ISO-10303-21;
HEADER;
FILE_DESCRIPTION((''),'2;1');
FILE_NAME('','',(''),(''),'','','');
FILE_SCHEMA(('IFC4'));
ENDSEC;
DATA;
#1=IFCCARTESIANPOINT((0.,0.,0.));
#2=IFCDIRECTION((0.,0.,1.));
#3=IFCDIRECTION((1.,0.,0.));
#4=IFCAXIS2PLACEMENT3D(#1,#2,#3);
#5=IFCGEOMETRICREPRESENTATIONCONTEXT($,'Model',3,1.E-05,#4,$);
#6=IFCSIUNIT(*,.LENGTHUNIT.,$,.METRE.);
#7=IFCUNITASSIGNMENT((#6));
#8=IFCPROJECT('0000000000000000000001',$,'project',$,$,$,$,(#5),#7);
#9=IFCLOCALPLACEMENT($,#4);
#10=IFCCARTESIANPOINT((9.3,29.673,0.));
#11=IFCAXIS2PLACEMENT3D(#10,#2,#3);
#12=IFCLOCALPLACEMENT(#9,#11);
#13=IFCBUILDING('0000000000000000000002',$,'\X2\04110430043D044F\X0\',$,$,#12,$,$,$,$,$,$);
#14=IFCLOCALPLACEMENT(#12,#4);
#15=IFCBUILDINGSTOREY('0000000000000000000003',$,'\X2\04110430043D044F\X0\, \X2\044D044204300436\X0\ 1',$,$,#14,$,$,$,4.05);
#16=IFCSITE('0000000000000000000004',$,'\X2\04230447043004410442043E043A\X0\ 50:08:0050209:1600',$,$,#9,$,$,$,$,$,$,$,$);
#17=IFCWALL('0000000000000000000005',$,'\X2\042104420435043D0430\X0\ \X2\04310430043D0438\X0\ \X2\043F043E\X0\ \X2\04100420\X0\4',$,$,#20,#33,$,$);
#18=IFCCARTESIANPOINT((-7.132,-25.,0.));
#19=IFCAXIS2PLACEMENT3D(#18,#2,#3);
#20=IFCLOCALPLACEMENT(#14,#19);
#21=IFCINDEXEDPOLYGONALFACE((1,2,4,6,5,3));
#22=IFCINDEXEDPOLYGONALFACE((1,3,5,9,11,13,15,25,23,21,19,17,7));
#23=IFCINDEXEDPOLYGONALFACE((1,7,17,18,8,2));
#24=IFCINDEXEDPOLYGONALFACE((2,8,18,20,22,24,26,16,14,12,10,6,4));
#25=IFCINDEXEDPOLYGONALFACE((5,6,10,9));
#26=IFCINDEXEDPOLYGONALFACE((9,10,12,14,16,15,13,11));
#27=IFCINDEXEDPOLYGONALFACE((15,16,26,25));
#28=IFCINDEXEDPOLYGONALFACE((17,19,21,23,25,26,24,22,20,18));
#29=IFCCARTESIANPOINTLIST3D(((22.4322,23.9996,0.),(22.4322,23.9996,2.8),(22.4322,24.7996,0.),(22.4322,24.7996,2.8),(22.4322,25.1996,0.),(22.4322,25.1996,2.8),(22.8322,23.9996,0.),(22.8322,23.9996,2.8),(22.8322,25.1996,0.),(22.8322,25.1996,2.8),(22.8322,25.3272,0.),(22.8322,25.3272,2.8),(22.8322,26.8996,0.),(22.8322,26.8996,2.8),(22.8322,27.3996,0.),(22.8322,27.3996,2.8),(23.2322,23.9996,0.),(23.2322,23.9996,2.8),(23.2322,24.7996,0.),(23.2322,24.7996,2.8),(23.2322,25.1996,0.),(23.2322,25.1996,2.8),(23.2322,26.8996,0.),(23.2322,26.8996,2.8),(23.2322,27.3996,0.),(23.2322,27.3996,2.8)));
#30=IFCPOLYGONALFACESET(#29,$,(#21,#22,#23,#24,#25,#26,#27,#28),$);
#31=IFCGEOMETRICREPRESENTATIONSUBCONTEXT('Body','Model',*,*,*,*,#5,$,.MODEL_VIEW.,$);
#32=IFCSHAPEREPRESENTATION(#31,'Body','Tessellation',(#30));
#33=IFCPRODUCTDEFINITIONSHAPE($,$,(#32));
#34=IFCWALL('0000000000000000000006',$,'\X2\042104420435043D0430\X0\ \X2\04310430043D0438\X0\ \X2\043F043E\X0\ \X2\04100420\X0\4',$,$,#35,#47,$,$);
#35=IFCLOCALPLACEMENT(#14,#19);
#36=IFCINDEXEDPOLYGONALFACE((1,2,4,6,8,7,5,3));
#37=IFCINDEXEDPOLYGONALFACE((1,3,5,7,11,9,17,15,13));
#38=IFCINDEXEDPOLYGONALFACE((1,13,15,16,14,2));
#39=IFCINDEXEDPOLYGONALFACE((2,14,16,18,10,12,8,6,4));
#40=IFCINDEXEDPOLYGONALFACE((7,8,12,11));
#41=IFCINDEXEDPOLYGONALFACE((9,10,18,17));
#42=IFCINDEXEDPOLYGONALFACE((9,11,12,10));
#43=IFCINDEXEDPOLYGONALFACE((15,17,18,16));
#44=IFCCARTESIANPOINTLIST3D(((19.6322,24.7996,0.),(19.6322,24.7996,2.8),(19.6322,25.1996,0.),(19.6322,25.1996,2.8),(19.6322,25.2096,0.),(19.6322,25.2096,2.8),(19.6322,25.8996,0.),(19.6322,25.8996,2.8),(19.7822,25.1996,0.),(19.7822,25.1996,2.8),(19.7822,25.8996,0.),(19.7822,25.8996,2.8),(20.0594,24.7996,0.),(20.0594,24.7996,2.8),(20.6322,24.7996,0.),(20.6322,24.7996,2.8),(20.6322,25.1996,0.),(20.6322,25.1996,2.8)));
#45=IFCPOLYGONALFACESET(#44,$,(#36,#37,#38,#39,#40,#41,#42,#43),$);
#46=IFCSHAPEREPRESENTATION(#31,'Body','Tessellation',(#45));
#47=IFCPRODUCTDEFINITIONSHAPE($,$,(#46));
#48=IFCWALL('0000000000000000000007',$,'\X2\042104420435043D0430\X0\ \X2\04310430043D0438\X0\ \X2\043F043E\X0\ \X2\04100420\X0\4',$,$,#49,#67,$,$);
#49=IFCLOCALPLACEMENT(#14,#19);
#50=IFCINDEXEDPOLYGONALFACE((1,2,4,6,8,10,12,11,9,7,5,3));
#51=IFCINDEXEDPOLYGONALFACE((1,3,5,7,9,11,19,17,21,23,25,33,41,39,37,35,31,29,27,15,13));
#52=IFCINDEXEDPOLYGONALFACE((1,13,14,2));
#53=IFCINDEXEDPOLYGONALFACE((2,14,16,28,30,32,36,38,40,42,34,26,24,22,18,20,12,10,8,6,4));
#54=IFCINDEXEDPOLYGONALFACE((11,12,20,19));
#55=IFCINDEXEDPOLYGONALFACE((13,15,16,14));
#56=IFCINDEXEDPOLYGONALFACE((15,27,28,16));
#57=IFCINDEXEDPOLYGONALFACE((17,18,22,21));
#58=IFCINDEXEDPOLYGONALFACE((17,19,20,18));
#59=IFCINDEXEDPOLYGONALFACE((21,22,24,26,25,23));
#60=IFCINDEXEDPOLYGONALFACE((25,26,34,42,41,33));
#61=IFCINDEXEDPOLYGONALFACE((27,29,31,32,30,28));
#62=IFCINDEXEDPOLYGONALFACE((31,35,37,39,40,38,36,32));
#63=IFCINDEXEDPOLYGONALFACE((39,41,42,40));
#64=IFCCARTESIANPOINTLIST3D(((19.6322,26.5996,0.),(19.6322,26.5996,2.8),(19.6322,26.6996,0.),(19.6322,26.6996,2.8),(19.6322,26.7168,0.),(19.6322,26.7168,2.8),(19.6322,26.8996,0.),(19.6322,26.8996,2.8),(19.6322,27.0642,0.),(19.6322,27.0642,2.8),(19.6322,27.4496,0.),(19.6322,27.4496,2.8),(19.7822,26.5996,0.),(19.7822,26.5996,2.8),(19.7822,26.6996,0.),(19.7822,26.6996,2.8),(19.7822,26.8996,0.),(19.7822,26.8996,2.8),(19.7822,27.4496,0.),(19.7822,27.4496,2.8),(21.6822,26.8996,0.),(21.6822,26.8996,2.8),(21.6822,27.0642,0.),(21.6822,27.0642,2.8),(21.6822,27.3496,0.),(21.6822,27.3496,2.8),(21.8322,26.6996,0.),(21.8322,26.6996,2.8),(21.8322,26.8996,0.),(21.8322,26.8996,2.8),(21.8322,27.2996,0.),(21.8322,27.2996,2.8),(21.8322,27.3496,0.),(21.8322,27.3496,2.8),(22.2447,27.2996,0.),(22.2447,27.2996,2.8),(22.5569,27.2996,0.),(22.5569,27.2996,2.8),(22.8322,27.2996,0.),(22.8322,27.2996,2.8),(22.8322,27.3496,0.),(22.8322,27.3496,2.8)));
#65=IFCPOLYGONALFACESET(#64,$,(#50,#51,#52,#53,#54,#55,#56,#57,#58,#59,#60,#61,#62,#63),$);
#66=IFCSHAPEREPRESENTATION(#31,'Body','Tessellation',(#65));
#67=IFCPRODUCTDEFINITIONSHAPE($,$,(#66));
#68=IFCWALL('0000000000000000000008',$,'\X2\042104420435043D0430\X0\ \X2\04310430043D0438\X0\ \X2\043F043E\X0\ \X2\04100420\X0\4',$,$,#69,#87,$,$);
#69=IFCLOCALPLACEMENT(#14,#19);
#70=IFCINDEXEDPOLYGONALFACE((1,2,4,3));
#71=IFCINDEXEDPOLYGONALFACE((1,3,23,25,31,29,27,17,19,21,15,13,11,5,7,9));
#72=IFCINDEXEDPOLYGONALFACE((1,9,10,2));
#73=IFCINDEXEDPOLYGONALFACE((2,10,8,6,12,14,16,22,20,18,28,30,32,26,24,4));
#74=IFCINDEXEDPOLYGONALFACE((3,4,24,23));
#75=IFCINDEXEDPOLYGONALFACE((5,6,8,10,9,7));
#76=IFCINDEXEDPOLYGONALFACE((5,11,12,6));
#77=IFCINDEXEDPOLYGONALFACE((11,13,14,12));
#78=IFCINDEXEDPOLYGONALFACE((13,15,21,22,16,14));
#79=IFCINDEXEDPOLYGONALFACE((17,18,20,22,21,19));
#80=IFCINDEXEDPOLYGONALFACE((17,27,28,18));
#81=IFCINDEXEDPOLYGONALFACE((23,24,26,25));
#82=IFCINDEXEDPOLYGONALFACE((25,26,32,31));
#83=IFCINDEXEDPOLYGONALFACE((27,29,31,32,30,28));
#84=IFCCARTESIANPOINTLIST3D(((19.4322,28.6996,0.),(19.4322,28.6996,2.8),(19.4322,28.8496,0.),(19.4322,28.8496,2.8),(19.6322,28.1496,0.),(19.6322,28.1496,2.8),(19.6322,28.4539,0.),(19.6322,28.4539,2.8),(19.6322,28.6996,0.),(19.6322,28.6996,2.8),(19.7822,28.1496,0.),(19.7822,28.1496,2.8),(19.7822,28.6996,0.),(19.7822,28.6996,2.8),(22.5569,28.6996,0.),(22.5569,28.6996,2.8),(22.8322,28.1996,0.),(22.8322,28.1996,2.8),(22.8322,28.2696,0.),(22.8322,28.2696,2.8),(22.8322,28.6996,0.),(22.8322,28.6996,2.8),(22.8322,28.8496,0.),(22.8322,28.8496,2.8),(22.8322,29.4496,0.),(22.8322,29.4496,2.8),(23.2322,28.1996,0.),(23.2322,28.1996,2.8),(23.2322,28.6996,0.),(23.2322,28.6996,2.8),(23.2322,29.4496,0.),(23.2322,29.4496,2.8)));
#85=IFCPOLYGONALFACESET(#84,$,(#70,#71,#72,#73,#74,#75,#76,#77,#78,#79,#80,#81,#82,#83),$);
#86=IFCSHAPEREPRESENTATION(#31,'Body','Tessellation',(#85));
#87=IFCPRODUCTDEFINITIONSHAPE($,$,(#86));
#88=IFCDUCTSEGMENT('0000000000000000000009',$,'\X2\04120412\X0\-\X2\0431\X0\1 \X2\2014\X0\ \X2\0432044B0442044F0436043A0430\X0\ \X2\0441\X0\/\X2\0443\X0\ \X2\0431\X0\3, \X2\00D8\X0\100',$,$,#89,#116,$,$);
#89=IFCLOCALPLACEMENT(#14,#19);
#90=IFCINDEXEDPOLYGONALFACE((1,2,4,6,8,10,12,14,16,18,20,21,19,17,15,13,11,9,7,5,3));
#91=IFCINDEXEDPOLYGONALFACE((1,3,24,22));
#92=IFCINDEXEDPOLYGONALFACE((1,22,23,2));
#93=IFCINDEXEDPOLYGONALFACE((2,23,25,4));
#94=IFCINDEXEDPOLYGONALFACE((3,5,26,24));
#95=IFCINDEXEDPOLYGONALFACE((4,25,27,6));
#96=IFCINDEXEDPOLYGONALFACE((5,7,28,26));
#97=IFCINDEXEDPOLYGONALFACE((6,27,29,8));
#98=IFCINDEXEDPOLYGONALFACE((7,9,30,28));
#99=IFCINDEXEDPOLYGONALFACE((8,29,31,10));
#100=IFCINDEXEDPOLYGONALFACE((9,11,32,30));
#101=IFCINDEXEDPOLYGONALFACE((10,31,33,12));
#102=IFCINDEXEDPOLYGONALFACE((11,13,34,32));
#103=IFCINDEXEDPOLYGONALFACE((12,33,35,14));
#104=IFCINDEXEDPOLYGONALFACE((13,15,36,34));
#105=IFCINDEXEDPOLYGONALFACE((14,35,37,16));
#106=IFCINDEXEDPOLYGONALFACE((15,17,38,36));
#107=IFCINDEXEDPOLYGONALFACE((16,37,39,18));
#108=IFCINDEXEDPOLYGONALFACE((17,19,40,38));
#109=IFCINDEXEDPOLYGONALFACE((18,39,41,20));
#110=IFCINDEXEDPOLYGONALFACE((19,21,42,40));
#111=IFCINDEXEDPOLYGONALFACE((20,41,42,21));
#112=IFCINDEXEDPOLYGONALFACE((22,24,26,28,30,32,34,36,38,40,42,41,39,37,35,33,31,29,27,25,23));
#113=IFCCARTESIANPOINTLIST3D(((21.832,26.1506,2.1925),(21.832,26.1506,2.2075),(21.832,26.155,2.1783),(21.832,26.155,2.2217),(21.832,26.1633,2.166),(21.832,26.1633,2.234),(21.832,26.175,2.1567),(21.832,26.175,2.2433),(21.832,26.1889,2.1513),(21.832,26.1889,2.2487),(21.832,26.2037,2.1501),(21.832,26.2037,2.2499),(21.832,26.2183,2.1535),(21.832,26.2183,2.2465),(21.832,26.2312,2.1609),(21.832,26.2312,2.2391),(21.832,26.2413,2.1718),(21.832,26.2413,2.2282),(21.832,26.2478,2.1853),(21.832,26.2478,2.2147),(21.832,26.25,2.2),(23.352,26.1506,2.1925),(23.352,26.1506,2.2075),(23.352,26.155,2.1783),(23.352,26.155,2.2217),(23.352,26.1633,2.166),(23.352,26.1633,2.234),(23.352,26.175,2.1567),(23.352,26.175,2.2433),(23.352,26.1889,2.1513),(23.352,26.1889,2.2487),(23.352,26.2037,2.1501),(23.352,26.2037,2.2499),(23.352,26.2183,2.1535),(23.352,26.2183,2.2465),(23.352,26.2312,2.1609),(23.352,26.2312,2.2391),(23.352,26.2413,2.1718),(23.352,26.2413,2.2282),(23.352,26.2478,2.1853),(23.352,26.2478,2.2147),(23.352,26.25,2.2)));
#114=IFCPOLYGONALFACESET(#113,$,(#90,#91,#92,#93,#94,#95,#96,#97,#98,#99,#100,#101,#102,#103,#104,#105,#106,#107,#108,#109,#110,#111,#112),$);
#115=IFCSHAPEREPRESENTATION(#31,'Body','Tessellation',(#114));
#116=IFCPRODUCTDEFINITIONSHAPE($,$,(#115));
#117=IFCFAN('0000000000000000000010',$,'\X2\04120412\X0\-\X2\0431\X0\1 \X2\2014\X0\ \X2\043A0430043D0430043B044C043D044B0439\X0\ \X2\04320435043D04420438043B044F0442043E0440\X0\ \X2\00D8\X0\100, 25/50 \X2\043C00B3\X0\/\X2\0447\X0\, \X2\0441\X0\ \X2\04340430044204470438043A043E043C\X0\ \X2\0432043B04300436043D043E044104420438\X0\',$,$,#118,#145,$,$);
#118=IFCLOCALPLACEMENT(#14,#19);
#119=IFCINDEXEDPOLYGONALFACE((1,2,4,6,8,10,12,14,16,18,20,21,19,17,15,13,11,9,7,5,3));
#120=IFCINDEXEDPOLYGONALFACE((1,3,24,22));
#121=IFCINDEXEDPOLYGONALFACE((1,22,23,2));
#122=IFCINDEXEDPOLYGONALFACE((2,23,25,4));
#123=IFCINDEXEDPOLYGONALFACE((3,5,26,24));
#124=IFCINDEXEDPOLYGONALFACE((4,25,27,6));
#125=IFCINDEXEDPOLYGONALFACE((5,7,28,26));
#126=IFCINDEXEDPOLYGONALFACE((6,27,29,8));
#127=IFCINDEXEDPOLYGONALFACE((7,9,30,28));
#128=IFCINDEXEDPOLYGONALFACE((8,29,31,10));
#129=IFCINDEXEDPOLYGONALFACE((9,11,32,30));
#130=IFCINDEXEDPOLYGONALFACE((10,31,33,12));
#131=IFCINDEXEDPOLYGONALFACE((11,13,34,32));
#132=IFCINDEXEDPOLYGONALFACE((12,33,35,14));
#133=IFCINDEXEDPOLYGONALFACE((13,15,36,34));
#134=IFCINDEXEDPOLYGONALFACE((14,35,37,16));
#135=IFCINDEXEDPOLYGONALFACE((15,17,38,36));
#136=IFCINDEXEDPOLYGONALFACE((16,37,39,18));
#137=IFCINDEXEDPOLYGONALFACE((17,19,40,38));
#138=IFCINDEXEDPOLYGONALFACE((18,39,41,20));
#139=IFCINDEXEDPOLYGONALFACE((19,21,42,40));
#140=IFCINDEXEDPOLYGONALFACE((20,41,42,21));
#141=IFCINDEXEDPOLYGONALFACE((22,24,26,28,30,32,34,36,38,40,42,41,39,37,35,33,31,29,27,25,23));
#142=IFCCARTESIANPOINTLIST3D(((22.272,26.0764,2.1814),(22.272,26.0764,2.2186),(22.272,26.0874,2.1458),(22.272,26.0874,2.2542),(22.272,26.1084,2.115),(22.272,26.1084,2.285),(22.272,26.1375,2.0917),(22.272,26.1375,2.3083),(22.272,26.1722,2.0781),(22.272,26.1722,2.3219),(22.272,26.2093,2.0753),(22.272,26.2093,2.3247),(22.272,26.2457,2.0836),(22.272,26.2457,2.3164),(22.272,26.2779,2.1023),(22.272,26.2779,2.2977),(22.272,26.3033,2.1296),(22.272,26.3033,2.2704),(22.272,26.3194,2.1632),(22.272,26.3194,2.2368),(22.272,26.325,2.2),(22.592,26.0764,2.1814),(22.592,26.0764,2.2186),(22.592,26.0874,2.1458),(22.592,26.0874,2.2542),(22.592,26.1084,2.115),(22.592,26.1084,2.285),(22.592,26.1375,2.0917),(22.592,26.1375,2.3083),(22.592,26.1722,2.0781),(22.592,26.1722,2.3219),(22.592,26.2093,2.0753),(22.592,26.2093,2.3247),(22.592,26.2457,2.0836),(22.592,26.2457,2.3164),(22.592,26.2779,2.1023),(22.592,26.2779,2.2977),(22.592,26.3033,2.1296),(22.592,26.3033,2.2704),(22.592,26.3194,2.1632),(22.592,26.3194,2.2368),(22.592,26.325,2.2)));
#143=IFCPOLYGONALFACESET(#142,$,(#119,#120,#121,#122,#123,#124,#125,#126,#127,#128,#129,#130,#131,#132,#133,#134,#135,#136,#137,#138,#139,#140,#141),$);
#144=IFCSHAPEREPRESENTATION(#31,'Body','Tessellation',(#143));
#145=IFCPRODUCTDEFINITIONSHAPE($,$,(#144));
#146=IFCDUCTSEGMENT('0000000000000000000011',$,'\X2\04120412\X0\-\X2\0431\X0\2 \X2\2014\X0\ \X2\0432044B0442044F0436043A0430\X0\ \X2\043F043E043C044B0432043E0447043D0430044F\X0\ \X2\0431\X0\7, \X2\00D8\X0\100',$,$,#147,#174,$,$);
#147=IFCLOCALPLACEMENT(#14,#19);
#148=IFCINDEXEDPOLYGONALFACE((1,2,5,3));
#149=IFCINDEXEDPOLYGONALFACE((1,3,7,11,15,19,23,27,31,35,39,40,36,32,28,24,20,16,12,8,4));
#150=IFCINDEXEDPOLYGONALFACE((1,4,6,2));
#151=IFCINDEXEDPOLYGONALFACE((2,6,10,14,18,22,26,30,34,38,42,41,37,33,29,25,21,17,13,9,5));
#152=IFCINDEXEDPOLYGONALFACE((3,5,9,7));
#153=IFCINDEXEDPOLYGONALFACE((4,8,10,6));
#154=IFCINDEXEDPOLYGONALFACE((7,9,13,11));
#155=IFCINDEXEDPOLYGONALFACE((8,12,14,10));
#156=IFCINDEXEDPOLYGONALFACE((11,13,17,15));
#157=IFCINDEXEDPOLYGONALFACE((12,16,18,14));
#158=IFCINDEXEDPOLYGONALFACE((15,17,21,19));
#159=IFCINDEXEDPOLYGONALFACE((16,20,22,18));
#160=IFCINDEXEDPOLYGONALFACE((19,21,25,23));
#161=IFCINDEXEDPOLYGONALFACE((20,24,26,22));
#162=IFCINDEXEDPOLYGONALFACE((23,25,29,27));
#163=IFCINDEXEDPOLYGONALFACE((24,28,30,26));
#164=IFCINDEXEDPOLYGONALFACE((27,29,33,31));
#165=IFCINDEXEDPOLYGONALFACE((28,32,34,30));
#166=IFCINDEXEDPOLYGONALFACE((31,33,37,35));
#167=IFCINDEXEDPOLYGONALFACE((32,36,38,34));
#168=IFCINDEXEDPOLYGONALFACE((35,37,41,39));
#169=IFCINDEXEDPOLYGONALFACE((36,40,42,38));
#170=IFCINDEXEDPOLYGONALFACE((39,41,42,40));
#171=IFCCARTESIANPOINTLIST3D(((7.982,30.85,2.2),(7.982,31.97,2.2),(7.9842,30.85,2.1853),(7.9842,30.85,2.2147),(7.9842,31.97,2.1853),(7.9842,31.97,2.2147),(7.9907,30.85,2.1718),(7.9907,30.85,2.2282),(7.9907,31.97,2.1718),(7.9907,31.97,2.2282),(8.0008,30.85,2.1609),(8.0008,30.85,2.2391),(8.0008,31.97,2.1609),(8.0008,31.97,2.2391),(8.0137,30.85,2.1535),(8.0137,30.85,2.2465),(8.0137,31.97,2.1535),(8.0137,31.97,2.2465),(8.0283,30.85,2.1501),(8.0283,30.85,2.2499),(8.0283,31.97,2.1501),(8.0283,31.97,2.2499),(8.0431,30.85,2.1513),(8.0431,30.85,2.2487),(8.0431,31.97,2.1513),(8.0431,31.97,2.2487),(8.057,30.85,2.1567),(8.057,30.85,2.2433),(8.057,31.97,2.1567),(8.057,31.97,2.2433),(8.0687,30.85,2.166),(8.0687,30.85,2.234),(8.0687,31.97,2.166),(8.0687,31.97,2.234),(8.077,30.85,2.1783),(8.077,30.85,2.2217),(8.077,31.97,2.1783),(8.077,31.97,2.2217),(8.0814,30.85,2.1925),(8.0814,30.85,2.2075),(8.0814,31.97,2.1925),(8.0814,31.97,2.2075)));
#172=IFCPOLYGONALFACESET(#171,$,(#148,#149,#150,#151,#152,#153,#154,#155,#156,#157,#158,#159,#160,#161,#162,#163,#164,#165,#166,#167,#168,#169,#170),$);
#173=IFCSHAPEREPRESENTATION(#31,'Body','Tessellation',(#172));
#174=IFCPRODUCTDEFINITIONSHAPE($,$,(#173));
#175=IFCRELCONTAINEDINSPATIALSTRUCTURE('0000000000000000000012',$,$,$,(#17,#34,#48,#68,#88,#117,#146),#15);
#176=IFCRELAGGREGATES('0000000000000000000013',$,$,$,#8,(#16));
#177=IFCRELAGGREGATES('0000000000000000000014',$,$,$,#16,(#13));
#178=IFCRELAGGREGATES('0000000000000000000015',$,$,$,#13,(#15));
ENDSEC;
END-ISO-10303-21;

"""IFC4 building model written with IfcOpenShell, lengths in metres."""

from ifc_helpers import new_model, si_unit, frame, origin_with_axes, origin_2d, place, context, subcontext, project, spatial, polyline, circle, outline, extrude, element, save


model = new_model("IFC4")

# Units and contexts
model_context = context("Model", 3, precision=1e-05, world=origin_with_axes())
body_context = subcontext(model_context, "Body", "Model", "MODEL_VIEW")
ifc_project = project(units=[si_unit("LENGTHUNIT", "METRE")], contexts=[model_context])

# Site, building, storey
site_placement = place(None, origin_with_axes())
site = spatial("IfcSite", under=ifc_project, at=site_placement, Name="Участок 50:08:0050209:1600")
building_placement = place(site_placement, frame((9.3, 29.673, 0.0), z_axis=(0.0, 0.0, 1.0), x_axis=(1.0, 0.0, 0.0)))
building = spatial("IfcBuilding", under=site, at=building_placement, Name="Баня")
storey_placement = place(building_placement, origin_with_axes())
storey = spatial("IfcBuildingStorey", under=building, at=storey_placement, Name="Баня, этаж 1", Elevation=4.05)

# Walls
wall_1_placement = place(storey_placement, frame((-7.132, -25.0, 0.0), z_axis=(0.0, 0.0, 1.0), x_axis=(1.0, 0.0, 0.0)))
element("IfcWall", 1, at=wall_1_placement, inside=storey, Name="Стена бани по АР4", context=body_context, shape_type="SweptSolid", body=[
    extrude(outline(polyline([(22.4322, 24.7996), (22.4322, 25.1996), (22.8322, 25.1996), (22.8322, 25.3272), (22.8322, 26.8996), (22.8322, 26.8996), (22.8322, 27.3996), (23.2322, 27.3996), (23.2322, 26.8996), (23.2322, 26.8996), (23.2322, 25.1996), (23.2322, 24.7996), (23.2322, 24.7996), (23.2322, 23.9996), (22.8322, 23.9996), (22.4322, 23.9996), (22.4322, 24.7996), (22.4322, 24.7996)])), origin_with_axes(), (0.0, 0.0, 1.0), 2.8),
])
wall_2_placement = place(storey_placement, frame((-7.132, -25.0, 0.0), z_axis=(0.0, 0.0, 1.0), x_axis=(1.0, 0.0, 0.0)))
element("IfcWall", 2, at=wall_2_placement, inside=storey, Name="Стена бани по АР4", context=body_context, shape_type="SweptSolid", body=[
    extrude(outline(polyline([(19.6322, 25.8996), (19.7822, 25.8996), (19.7822, 25.1996), (20.6322, 25.1996), (20.6322, 24.7996), (20.0594, 24.7996), (19.6322, 24.7996), (19.6322, 25.1996), (19.6322, 25.2096), (19.6322, 25.8996)])), origin_with_axes(), (0.0, 0.0, 1.0), 2.8),
])
wall_3_placement = place(storey_placement, frame((-7.132, -25.0, 0.0), z_axis=(0.0, 0.0, 1.0), x_axis=(1.0, 0.0, 0.0)))
element("IfcWall", 3, at=wall_3_placement, inside=storey, Name="Стена бани по АР4", context=body_context, shape_type="SweptSolid", body=[
    extrude(outline(polyline([(19.6322, 27.0642), (19.6322, 27.4496), (19.7822, 27.4496), (19.7822, 26.8996), (21.6822, 26.8996), (21.6822, 27.0642), (21.6822, 27.3496), (21.8322, 27.3496), (22.8322, 27.3496), (22.8322, 27.2996), (22.5569, 27.2996), (22.2447, 27.2996), (21.8322, 27.2996), (21.8322, 26.8996), (21.8322, 26.6996), (19.7822, 26.6996), (19.7822, 26.5996), (19.6322, 26.5996), (19.6322, 26.6996), (19.6322, 26.7168), (19.6322, 26.8996), (19.6322, 27.0642)])), origin_with_axes(), (0.0, 0.0, 1.0), 2.8),
])
wall_4_placement = place(storey_placement, frame((-7.132, -25.0, 0.0), z_axis=(0.0, 0.0, 1.0), x_axis=(1.0, 0.0, 0.0)))
element("IfcWall", 4, at=wall_4_placement, inside=storey, Name="Стена бани по АР4", context=body_context, shape_type="SweptSolid", body=[
    extrude(outline(polyline([(19.6322, 28.4539), (19.6322, 28.6996), (19.4322, 28.6996), (19.4322, 28.8496), (22.8322, 28.8496), (22.8322, 29.4496), (23.2322, 29.4496), (23.2322, 28.6996), (23.2322, 28.6996), (23.2322, 28.1996), (22.8322, 28.1996), (22.8322, 28.2696), (22.8322, 28.6996), (22.8322, 28.6996), (22.5569, 28.6996), (19.7822, 28.6996), (19.7822, 28.1496), (19.6322, 28.1496), (19.6322, 28.4539)])), origin_with_axes(), (0.0, 0.0, 1.0), 2.8),
])

# Duct segment
duct_segment_1_placement = place(storey_placement, frame((-7.132, -25.0, 0.0), z_axis=(0.0, 0.0, 1.0), x_axis=(1.0, 0.0, 0.0)))
element("IfcDuctSegment", 5, at=duct_segment_1_placement, inside=storey, Name="ВВ-б1 — вытяжка с/у б3, Ø100", context=body_context, shape_type="SweptSolid", body=[
    extrude(circle(Radius=0.05, at=origin_2d()), frame((21.832, 26.2, 2.2), z_axis=(1.0, 0.0, 0.0), x_axis=(0.0, 1.0, 0.0)), (0.0, 0.0, 1.0), 1.52),
])

# Fan
fan_1_placement = place(storey_placement, frame((-7.132, -25.0, 0.0), z_axis=(0.0, 0.0, 1.0), x_axis=(1.0, 0.0, 0.0)))
element("IfcFan", 6, at=fan_1_placement, inside=storey, Name="ВВ-б1 — канальный вентилятор Ø100, 25/50 м³/ч, с датчиком влажности", context=body_context, shape_type="SweptSolid", body=[
    extrude(circle(Radius=0.125, at=origin_2d()), frame((22.272, 26.2, 2.2), z_axis=(1.0, 0.0, 0.0), x_axis=(0.0, 1.0, 0.0)), (0.0, 0.0, 1.0), 0.32),
])

# Duct segment
duct_segment_2_placement = place(storey_placement, frame((-7.132, -25.0, 0.0), z_axis=(0.0, 0.0, 1.0), x_axis=(1.0, 0.0, 0.0)))
element("IfcDuctSegment", 7, at=duct_segment_2_placement, inside=storey, Name="ВВ-б2 — вытяжка помывочная б7, Ø100", context=body_context, shape_type="SweptSolid", body=[
    extrude(circle(Radius=0.05, at=origin_2d()), frame((8.032, 30.85, 2.2), z_axis=(0.0, 1.0, 0.0), x_axis=(-1.0, 0.0, 0.0)), (0.0, 0.0, 1.0), 1.12),
])

save(model, "model.ifc")
